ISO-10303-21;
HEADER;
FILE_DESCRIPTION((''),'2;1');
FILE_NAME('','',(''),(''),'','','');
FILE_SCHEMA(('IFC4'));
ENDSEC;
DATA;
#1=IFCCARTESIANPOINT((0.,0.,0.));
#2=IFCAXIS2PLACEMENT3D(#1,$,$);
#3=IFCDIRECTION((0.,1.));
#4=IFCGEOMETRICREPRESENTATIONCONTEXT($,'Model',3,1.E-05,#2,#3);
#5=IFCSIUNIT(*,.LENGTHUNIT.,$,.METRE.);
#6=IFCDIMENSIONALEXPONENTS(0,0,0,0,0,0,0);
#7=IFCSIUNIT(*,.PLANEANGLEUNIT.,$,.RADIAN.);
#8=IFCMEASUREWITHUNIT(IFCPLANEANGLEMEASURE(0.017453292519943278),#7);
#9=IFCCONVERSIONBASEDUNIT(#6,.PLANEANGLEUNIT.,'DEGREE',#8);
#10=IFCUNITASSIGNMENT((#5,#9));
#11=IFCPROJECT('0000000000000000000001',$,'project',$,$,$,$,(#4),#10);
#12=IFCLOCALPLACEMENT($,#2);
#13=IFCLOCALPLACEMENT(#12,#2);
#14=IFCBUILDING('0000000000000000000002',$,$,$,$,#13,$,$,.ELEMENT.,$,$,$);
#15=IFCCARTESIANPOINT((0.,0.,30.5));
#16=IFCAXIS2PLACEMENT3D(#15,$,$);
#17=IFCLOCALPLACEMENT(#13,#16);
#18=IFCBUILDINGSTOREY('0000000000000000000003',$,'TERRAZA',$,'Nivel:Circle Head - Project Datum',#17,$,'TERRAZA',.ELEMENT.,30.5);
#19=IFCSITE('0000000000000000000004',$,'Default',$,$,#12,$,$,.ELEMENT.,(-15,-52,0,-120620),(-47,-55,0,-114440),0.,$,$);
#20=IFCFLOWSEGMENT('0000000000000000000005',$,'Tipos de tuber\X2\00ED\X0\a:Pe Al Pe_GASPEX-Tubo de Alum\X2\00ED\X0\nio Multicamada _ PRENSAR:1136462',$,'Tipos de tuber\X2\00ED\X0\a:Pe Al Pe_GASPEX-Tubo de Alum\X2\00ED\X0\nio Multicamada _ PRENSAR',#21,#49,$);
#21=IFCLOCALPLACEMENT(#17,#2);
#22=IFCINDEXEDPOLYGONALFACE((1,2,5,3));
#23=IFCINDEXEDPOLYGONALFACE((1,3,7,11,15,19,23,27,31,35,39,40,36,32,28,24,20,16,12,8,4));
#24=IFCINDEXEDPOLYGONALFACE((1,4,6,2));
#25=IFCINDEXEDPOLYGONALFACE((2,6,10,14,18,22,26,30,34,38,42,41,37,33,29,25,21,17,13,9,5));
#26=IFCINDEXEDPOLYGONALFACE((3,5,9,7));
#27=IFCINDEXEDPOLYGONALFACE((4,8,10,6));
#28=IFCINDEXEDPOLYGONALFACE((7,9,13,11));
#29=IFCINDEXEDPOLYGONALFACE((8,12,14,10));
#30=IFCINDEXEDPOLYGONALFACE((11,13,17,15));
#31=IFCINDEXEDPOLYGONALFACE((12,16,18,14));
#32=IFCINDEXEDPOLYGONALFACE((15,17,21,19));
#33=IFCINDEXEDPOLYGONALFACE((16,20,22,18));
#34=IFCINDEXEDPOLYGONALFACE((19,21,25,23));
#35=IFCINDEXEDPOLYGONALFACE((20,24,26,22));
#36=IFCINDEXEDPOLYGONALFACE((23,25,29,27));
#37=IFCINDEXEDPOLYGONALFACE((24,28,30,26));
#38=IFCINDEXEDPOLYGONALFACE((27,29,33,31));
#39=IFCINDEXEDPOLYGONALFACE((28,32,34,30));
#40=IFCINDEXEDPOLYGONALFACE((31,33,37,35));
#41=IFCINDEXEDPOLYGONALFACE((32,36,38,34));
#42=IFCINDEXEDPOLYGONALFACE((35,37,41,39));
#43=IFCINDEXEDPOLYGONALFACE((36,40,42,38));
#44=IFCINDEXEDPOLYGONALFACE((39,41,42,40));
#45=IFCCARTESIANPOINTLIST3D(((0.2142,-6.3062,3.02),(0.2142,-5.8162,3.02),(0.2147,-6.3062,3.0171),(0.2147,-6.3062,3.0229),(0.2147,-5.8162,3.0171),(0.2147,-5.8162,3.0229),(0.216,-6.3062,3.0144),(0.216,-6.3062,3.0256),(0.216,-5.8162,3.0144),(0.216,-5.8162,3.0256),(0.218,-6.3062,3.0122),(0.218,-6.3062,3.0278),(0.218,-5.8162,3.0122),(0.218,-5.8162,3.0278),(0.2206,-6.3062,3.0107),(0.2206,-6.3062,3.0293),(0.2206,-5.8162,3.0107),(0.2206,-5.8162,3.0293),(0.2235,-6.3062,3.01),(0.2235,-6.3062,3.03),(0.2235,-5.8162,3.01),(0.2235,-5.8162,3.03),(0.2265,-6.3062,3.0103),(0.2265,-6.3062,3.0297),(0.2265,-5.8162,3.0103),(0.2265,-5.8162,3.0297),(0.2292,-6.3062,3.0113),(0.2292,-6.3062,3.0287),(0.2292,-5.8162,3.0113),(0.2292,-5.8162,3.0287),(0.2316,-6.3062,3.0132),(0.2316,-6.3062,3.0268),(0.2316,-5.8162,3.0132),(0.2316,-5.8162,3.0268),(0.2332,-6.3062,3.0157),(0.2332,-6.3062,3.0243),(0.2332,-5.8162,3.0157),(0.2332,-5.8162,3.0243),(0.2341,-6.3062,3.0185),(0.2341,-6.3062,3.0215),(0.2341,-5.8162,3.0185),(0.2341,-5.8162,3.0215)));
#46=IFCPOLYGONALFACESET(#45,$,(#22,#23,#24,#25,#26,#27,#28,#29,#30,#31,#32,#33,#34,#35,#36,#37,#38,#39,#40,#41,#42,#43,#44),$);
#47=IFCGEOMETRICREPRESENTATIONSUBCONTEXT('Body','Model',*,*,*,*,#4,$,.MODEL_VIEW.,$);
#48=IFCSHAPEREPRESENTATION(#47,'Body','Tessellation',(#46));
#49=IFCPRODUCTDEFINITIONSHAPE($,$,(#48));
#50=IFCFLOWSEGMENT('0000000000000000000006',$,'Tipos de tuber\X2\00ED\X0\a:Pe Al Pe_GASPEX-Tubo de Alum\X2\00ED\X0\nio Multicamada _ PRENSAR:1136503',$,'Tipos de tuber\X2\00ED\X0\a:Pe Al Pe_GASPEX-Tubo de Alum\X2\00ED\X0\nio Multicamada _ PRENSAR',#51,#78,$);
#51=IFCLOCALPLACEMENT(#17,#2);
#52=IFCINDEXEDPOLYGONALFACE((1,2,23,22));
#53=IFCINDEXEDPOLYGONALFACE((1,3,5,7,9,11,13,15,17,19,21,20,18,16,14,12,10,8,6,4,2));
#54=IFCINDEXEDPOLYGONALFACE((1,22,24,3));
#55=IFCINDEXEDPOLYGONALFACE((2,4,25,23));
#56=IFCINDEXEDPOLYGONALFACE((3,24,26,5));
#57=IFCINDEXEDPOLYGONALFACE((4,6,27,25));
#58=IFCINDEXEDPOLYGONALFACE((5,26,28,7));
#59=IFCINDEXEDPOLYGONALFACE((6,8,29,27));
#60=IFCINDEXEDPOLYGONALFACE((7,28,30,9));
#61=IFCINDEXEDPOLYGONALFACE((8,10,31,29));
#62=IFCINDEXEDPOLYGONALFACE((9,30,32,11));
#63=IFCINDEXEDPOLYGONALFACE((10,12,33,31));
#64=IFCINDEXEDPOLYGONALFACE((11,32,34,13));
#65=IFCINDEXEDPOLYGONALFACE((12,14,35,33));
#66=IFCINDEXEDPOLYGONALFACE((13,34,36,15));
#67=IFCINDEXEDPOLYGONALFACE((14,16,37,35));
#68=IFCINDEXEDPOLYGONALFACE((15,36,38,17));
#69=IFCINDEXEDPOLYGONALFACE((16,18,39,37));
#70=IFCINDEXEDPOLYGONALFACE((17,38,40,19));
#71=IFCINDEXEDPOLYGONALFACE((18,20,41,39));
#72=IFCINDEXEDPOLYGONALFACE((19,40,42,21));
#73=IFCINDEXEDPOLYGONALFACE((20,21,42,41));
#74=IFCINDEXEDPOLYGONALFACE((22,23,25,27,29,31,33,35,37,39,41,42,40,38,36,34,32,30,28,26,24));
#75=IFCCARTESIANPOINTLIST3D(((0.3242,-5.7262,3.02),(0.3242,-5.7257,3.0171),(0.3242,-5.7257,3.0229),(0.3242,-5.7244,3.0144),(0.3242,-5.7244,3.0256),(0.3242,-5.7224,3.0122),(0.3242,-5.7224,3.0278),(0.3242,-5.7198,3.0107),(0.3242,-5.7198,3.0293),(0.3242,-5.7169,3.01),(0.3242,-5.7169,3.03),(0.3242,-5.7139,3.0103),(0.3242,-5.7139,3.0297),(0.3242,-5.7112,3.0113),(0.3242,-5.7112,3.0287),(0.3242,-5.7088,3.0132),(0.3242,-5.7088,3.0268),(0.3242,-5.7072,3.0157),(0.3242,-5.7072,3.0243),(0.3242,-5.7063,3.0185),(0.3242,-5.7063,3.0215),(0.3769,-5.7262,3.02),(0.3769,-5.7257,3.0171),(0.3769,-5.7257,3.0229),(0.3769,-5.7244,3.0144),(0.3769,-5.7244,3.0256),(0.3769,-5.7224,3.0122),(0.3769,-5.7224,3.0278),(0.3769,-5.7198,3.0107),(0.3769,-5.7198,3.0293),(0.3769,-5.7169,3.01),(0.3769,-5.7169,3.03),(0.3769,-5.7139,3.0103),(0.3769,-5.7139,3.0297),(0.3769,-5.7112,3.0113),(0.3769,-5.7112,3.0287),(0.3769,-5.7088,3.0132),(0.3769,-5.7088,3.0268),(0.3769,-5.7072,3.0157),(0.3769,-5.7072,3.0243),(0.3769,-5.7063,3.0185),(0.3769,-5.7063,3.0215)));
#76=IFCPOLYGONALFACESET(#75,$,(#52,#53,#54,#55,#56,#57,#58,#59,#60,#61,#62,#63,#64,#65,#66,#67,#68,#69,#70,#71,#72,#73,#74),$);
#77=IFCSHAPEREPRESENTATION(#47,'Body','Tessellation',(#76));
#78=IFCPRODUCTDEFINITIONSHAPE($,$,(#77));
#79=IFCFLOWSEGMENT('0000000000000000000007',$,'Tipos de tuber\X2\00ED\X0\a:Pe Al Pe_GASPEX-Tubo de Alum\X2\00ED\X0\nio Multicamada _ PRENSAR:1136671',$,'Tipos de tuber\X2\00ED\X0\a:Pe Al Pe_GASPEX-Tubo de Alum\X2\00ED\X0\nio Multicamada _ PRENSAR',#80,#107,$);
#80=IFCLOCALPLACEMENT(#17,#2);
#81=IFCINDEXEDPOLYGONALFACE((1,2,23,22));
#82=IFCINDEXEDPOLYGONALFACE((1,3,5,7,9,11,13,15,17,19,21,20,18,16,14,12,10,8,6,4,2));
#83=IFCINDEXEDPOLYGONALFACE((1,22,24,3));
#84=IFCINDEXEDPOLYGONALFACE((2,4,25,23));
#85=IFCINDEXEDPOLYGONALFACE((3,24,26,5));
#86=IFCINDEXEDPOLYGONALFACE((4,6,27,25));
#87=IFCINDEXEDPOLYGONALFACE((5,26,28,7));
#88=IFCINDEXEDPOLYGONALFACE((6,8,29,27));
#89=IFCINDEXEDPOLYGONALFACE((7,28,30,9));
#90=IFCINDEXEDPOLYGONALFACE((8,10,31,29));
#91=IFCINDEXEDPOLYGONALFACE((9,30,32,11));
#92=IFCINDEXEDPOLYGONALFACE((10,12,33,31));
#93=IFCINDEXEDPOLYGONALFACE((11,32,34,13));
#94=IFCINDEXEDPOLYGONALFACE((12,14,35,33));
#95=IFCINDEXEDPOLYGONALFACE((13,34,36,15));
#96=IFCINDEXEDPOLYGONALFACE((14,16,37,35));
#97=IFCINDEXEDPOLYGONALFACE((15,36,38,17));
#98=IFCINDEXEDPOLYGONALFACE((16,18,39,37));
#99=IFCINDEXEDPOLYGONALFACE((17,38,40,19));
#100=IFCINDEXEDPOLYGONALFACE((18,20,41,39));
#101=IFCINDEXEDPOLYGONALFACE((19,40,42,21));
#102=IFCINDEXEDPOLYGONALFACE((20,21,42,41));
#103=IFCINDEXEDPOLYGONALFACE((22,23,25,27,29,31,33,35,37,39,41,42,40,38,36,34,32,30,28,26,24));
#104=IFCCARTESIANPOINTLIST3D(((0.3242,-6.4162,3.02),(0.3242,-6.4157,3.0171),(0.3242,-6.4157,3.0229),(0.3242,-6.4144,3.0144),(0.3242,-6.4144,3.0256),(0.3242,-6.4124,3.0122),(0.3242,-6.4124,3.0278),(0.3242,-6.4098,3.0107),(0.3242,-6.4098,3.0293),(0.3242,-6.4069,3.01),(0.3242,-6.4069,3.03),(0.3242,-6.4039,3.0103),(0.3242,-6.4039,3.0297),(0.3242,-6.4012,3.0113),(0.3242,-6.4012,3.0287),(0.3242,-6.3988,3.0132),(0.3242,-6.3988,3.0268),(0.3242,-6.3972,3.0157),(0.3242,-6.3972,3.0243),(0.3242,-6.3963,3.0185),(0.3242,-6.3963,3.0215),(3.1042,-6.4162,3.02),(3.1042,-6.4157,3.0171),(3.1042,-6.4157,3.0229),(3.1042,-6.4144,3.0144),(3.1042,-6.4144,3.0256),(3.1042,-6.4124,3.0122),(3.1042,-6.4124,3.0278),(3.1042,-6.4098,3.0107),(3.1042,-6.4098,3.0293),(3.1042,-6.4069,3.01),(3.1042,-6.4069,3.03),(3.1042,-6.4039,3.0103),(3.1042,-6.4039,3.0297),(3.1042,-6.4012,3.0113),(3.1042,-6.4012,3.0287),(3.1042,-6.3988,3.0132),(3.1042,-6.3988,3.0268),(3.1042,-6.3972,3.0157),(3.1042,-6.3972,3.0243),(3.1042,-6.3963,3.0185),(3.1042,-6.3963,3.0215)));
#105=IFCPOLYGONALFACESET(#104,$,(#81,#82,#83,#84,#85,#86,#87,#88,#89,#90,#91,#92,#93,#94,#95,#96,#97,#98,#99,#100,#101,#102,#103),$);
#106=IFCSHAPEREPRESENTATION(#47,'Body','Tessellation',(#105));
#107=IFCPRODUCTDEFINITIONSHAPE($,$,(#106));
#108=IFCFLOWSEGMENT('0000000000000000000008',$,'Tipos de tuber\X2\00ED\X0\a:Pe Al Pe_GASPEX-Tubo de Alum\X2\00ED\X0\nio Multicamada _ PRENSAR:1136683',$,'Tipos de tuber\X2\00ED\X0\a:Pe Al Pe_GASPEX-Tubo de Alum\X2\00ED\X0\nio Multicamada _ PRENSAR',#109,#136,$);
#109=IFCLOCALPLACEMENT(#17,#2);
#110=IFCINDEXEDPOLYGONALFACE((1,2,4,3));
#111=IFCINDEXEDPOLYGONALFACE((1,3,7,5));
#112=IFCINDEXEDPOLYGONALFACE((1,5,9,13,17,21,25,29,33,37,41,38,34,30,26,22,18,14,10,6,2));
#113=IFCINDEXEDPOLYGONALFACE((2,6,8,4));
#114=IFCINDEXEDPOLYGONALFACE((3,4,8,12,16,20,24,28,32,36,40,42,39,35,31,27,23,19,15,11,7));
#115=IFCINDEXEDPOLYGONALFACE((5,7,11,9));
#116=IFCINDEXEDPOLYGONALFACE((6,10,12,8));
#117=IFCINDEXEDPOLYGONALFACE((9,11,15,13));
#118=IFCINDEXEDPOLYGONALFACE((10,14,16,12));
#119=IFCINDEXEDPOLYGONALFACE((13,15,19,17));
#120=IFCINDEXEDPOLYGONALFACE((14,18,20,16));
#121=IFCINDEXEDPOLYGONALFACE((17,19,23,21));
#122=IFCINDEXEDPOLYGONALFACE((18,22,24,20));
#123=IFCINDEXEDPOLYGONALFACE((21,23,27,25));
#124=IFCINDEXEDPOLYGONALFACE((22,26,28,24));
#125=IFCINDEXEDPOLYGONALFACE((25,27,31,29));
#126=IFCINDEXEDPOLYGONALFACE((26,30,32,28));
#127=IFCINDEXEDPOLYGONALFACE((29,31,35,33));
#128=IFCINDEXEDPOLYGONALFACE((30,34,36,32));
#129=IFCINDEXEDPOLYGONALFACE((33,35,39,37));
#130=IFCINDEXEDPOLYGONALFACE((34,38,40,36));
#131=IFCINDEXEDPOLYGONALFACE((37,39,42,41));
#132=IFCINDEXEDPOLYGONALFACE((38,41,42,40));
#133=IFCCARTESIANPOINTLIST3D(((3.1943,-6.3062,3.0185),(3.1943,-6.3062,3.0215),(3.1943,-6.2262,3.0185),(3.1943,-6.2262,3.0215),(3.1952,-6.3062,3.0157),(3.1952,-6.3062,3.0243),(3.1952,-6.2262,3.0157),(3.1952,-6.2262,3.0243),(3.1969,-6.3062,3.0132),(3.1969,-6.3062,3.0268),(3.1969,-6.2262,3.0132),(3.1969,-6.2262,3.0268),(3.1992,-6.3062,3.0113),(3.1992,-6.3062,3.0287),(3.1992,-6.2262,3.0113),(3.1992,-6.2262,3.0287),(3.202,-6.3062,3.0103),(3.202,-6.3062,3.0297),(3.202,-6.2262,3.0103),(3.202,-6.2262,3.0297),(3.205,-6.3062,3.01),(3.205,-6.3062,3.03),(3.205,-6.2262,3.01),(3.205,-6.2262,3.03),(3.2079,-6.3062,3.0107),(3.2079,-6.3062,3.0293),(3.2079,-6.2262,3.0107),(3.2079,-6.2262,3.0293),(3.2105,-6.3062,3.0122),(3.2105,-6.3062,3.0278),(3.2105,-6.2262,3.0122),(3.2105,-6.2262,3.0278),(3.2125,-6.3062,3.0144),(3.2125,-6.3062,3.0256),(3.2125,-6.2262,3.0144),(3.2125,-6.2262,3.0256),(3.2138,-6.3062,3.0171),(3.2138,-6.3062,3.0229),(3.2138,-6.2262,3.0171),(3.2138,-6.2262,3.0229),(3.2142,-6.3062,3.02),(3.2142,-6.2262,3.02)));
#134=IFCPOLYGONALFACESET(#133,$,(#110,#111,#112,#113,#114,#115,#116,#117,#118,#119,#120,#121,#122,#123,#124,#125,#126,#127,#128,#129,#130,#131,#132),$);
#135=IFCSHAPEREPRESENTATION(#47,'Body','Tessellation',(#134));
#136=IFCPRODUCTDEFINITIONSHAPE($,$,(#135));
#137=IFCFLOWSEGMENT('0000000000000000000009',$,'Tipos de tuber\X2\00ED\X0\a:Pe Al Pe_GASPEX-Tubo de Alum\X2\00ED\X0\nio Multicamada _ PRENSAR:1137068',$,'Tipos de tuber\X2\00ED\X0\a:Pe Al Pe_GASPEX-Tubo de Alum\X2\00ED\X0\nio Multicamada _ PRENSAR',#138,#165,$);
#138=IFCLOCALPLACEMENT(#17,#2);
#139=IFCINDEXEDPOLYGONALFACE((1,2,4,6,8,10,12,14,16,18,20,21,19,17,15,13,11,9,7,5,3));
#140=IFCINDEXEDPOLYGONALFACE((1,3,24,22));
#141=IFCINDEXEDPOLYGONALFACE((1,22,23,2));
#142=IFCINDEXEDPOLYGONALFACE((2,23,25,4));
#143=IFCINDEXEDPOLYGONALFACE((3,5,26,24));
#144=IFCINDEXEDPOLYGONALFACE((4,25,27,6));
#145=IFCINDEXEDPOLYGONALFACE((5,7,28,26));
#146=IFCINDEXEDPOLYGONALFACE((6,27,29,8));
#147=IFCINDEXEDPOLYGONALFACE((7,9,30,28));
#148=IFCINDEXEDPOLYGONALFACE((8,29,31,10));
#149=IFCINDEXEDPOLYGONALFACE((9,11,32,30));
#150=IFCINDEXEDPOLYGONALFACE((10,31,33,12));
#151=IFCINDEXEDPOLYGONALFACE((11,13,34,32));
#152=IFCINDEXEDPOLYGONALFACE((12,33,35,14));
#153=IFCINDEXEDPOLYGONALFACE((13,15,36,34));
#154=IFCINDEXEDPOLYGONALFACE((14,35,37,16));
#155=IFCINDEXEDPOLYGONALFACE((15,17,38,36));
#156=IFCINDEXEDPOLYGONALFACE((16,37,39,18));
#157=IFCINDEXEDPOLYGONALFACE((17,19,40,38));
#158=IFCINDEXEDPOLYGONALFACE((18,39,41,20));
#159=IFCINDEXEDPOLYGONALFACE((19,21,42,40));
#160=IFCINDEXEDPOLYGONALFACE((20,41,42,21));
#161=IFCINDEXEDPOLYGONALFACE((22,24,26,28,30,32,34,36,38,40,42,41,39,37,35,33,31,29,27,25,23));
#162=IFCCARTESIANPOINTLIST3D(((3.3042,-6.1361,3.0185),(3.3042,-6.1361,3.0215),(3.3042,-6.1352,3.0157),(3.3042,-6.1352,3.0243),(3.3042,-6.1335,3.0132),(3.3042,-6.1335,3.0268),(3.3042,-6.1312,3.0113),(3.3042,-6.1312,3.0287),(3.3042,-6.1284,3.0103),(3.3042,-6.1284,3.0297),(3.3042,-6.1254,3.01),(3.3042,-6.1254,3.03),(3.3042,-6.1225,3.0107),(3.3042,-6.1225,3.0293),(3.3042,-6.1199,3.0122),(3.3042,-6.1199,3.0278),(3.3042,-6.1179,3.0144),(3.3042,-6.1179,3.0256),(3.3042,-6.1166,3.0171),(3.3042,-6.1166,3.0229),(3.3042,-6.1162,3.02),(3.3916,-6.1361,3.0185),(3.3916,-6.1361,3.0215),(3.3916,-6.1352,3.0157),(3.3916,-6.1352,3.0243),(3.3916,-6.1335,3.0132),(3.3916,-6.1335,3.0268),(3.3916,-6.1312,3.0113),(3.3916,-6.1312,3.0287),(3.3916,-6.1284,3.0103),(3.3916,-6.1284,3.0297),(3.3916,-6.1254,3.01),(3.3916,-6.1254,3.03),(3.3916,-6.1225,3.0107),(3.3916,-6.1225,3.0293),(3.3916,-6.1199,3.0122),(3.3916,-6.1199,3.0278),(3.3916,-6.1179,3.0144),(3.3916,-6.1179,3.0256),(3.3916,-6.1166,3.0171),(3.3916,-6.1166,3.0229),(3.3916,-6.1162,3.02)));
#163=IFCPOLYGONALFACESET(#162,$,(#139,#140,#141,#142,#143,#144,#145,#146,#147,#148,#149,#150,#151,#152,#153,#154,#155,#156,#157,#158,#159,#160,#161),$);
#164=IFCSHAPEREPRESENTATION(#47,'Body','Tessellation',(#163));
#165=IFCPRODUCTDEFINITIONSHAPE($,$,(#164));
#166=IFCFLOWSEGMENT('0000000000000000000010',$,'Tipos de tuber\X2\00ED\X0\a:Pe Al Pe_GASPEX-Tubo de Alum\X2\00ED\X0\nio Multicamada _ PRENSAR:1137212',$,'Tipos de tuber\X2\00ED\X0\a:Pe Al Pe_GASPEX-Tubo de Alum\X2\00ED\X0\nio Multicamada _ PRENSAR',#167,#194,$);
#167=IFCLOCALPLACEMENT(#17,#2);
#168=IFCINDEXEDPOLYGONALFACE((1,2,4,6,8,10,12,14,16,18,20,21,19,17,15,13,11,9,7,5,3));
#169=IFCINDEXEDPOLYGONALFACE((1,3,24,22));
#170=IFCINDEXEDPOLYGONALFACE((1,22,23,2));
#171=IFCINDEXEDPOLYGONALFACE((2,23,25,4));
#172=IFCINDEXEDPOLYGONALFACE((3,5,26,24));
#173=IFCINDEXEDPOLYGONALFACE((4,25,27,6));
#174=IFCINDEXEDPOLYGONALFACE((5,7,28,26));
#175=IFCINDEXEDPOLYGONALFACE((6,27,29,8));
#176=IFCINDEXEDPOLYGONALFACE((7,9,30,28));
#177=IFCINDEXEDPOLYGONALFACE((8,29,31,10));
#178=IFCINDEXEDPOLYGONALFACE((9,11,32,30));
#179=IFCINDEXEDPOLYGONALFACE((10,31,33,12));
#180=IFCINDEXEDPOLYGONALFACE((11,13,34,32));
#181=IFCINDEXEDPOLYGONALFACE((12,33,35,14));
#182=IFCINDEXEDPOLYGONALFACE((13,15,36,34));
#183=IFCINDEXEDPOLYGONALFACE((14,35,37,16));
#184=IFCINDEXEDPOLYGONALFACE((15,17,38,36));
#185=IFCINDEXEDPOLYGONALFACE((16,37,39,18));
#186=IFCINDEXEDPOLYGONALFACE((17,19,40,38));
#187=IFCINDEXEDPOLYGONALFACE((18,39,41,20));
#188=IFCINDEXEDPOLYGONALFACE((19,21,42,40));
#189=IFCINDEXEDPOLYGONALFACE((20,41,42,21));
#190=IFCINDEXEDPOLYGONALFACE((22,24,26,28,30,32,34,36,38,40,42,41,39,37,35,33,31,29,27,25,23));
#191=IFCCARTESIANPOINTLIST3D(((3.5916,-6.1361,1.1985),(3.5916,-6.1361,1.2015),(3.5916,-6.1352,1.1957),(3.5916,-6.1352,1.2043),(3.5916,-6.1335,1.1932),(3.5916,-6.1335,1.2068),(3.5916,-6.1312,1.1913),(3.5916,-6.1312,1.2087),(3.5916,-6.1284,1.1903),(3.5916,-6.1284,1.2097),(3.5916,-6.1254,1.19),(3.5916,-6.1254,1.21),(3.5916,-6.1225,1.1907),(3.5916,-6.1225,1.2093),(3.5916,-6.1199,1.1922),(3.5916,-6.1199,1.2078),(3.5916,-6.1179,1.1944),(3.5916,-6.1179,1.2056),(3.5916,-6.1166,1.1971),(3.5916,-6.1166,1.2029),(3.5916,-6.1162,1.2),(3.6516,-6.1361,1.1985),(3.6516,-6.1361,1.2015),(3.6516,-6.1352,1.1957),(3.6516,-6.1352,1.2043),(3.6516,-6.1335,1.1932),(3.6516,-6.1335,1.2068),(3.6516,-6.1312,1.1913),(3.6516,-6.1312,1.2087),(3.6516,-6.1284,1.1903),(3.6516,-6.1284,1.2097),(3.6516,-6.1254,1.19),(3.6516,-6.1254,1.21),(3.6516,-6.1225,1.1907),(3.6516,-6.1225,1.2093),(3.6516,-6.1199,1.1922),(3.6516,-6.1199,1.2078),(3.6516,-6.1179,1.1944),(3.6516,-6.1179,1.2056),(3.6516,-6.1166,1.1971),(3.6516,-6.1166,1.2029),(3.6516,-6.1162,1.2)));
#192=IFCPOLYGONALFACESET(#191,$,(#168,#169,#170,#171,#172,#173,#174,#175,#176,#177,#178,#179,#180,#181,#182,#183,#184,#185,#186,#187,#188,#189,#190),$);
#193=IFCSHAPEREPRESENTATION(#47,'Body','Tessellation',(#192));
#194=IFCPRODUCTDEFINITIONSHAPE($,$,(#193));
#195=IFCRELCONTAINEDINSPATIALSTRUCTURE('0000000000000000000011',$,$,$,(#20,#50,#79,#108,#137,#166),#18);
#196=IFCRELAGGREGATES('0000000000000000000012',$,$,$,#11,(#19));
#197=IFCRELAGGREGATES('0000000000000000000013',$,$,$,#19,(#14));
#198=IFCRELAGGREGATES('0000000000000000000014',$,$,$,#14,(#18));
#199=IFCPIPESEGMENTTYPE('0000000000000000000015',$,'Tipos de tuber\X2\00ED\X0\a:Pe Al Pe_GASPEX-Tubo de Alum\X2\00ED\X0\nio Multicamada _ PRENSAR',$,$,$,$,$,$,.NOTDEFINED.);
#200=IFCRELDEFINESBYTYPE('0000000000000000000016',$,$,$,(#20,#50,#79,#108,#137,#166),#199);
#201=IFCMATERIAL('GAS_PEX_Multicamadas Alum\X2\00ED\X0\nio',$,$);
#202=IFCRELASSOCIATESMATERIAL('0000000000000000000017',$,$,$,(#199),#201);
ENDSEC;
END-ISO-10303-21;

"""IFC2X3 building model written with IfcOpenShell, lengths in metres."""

from ifc_helpers import new_model, entity, si_unit, converted_unit, direction, frame, frame_2d, origin, origin_2d_with_axis, place, context, subcontext, project, spatial, circle, extrude, material, type_object, element, save


model = new_model("IFC2X3")

# Units and contexts
model_context = context("Model", 3, precision=1e-05, world=origin(), true_north=direction((0.0, 1.0)))
body_context = subcontext(model_context, "Body", "Model", "MODEL_VIEW")
ifc_project = project(units=[si_unit("LENGTHUNIT", "METRE"), converted_unit("PLANEANGLEUNIT", "DEGREE", entity("IfcPlaneAngleMeasure", 0.017453292519943278), si_unit("PLANEANGLEUNIT", "RADIAN"), dimensions=[0, 0, 0, 0, 0, 0, 0])], contexts=[model_context])

# Site, building, storey
site_placement = place(None, origin())
site = spatial("IfcSite", under=ifc_project, at=site_placement, Name="Default", CompositionType="ELEMENT", RefLatitude=(-15, -52, 0, -120620), RefLongitude=(-47, -55, 0, -114440), RefElevation=0.0)
building_placement = place(site_placement, origin())
building = spatial("IfcBuilding", under=site, at=building_placement, CompositionType="ELEMENT")
storey_placement = place(building_placement, frame((0.0, 0.0, 30.5)))
storey = spatial("IfcBuildingStorey", under=building, at=storey_placement, Name="TERRAZA", ObjectType="Nivel:Circle Head - Project Datum", LongName="TERRAZA", CompositionType="ELEMENT", Elevation=30.5)

# Flow segments
ifc_material = material(Name="GAS_PEX_Multicamadas Alumínio")
pipe_segment_type = type_object("IfcPipeSegmentType", Name="Tipos de tubería:Pe Al Pe_GASPEX-Tubo de Alumínio Multicamada _ PRENSAR", PredefinedType="NOTDEFINED", material=ifc_material)
flow_segment_1_placement = place(storey_placement, origin())
element("IfcFlowSegment", 1, at=flow_segment_1_placement, inside=storey, type_object=pipe_segment_type, Name="Tipos de tubería:Pe Al Pe_GASPEX-Tubo de Alumínio Multicamada _ PRENSAR:1136462", ObjectType="Tipos de tubería:Pe Al Pe_GASPEX-Tubo de Alumínio Multicamada _ PRENSAR", context=body_context, shape_type="SweptSolid", body=[
    extrude(circle(Radius=0.01, at=frame_2d((0.0, 0.0), x_axis=(1.0, 0.0))), frame((0.2242, -6.3062, 3.02), z_axis=(0.0, 1.0, 0.0), x_axis=(-1.0, 0.0, 0.0)), (0.0, 0.0, 1.0), 0.49),
])
flow_segment_2_placement = place(storey_placement, origin())
element("IfcFlowSegment", 2, at=flow_segment_2_placement, inside=storey, type_object=pipe_segment_type, Name="Tipos de tubería:Pe Al Pe_GASPEX-Tubo de Alumínio Multicamada _ PRENSAR:1136503", ObjectType="Tipos de tubería:Pe Al Pe_GASPEX-Tubo de Alumínio Multicamada _ PRENSAR", context=body_context, shape_type="SweptSolid", body=[
    extrude(circle(Radius=0.01, at=origin_2d_with_axis()), frame((0.3242, -5.7162, 3.02), z_axis=(1.0, 0.0, 0.0), x_axis=(0.0, -1.0, 0.0)), (0.0, 0.0, 1.0), 0.0527),
])
flow_segment_3_placement = place(storey_placement, origin())
element("IfcFlowSegment", 3, at=flow_segment_3_placement, inside=storey, type_object=pipe_segment_type, Name="Tipos de tubería:Pe Al Pe_GASPEX-Tubo de Alumínio Multicamada _ PRENSAR:1136671", ObjectType="Tipos de tubería:Pe Al Pe_GASPEX-Tubo de Alumínio Multicamada _ PRENSAR", context=body_context, shape_type="SweptSolid", body=[
    extrude(circle(Radius=0.01, at=origin_2d_with_axis()), frame((0.3242, -6.4062, 3.02), z_axis=(1.0, 0.0, 0.0), x_axis=(0.0, -1.0, 0.0)), (0.0, 0.0, 1.0), 2.78),
])
flow_segment_4_placement = place(storey_placement, origin())
element("IfcFlowSegment", 4, at=flow_segment_4_placement, inside=storey, type_object=pipe_segment_type, Name="Tipos de tubería:Pe Al Pe_GASPEX-Tubo de Alumínio Multicamada _ PRENSAR:1136683", ObjectType="Tipos de tubería:Pe Al Pe_GASPEX-Tubo de Alumínio Multicamada _ PRENSAR", context=body_context, shape_type="SweptSolid", body=[
    extrude(circle(Radius=0.01, at=origin_2d_with_axis()), frame((3.2042, -6.3062, 3.02), z_axis=(0.0, 1.0, 0.0), x_axis=(1.0, 0.0, 0.0)), (0.0, 0.0, 1.0), 0.08),
])
flow_segment_5_placement = place(storey_placement, origin())
element("IfcFlowSegment", 5, at=flow_segment_5_placement, inside=storey, type_object=pipe_segment_type, Name="Tipos de tubería:Pe Al Pe_GASPEX-Tubo de Alumínio Multicamada _ PRENSAR:1137068", ObjectType="Tipos de tubería:Pe Al Pe_GASPEX-Tubo de Alumínio Multicamada _ PRENSAR", context=body_context, shape_type="SweptSolid", body=[
    extrude(circle(Radius=0.01, at=frame_2d((0.0, 0.0), x_axis=(1.0, 0.0))), frame((3.3042, -6.1262, 3.02), z_axis=(1.0, 0.0, 0.0), x_axis=(0.0, 1.0, 0.0)), (0.0, 0.0, 1.0), 0.0874),
])
flow_segment_6_placement = place(storey_placement, origin())
element("IfcFlowSegment", 6, at=flow_segment_6_placement, inside=storey, type_object=pipe_segment_type, Name="Tipos de tubería:Pe Al Pe_GASPEX-Tubo de Alumínio Multicamada _ PRENSAR:1137212", ObjectType="Tipos de tubería:Pe Al Pe_GASPEX-Tubo de Alumínio Multicamada _ PRENSAR", context=body_context, shape_type="SweptSolid", body=[
    extrude(circle(Radius=0.01, at=frame_2d((0.0, 0.0), x_axis=(1.0, 0.0))), frame((3.5916, -6.1262, 1.2), z_axis=(1.0, 0.0, 0.0), x_axis=(0.0, 1.0, 0.0)), (0.0, 0.0, 1.0), 0.06),
])

save(model, "model.ifc")
